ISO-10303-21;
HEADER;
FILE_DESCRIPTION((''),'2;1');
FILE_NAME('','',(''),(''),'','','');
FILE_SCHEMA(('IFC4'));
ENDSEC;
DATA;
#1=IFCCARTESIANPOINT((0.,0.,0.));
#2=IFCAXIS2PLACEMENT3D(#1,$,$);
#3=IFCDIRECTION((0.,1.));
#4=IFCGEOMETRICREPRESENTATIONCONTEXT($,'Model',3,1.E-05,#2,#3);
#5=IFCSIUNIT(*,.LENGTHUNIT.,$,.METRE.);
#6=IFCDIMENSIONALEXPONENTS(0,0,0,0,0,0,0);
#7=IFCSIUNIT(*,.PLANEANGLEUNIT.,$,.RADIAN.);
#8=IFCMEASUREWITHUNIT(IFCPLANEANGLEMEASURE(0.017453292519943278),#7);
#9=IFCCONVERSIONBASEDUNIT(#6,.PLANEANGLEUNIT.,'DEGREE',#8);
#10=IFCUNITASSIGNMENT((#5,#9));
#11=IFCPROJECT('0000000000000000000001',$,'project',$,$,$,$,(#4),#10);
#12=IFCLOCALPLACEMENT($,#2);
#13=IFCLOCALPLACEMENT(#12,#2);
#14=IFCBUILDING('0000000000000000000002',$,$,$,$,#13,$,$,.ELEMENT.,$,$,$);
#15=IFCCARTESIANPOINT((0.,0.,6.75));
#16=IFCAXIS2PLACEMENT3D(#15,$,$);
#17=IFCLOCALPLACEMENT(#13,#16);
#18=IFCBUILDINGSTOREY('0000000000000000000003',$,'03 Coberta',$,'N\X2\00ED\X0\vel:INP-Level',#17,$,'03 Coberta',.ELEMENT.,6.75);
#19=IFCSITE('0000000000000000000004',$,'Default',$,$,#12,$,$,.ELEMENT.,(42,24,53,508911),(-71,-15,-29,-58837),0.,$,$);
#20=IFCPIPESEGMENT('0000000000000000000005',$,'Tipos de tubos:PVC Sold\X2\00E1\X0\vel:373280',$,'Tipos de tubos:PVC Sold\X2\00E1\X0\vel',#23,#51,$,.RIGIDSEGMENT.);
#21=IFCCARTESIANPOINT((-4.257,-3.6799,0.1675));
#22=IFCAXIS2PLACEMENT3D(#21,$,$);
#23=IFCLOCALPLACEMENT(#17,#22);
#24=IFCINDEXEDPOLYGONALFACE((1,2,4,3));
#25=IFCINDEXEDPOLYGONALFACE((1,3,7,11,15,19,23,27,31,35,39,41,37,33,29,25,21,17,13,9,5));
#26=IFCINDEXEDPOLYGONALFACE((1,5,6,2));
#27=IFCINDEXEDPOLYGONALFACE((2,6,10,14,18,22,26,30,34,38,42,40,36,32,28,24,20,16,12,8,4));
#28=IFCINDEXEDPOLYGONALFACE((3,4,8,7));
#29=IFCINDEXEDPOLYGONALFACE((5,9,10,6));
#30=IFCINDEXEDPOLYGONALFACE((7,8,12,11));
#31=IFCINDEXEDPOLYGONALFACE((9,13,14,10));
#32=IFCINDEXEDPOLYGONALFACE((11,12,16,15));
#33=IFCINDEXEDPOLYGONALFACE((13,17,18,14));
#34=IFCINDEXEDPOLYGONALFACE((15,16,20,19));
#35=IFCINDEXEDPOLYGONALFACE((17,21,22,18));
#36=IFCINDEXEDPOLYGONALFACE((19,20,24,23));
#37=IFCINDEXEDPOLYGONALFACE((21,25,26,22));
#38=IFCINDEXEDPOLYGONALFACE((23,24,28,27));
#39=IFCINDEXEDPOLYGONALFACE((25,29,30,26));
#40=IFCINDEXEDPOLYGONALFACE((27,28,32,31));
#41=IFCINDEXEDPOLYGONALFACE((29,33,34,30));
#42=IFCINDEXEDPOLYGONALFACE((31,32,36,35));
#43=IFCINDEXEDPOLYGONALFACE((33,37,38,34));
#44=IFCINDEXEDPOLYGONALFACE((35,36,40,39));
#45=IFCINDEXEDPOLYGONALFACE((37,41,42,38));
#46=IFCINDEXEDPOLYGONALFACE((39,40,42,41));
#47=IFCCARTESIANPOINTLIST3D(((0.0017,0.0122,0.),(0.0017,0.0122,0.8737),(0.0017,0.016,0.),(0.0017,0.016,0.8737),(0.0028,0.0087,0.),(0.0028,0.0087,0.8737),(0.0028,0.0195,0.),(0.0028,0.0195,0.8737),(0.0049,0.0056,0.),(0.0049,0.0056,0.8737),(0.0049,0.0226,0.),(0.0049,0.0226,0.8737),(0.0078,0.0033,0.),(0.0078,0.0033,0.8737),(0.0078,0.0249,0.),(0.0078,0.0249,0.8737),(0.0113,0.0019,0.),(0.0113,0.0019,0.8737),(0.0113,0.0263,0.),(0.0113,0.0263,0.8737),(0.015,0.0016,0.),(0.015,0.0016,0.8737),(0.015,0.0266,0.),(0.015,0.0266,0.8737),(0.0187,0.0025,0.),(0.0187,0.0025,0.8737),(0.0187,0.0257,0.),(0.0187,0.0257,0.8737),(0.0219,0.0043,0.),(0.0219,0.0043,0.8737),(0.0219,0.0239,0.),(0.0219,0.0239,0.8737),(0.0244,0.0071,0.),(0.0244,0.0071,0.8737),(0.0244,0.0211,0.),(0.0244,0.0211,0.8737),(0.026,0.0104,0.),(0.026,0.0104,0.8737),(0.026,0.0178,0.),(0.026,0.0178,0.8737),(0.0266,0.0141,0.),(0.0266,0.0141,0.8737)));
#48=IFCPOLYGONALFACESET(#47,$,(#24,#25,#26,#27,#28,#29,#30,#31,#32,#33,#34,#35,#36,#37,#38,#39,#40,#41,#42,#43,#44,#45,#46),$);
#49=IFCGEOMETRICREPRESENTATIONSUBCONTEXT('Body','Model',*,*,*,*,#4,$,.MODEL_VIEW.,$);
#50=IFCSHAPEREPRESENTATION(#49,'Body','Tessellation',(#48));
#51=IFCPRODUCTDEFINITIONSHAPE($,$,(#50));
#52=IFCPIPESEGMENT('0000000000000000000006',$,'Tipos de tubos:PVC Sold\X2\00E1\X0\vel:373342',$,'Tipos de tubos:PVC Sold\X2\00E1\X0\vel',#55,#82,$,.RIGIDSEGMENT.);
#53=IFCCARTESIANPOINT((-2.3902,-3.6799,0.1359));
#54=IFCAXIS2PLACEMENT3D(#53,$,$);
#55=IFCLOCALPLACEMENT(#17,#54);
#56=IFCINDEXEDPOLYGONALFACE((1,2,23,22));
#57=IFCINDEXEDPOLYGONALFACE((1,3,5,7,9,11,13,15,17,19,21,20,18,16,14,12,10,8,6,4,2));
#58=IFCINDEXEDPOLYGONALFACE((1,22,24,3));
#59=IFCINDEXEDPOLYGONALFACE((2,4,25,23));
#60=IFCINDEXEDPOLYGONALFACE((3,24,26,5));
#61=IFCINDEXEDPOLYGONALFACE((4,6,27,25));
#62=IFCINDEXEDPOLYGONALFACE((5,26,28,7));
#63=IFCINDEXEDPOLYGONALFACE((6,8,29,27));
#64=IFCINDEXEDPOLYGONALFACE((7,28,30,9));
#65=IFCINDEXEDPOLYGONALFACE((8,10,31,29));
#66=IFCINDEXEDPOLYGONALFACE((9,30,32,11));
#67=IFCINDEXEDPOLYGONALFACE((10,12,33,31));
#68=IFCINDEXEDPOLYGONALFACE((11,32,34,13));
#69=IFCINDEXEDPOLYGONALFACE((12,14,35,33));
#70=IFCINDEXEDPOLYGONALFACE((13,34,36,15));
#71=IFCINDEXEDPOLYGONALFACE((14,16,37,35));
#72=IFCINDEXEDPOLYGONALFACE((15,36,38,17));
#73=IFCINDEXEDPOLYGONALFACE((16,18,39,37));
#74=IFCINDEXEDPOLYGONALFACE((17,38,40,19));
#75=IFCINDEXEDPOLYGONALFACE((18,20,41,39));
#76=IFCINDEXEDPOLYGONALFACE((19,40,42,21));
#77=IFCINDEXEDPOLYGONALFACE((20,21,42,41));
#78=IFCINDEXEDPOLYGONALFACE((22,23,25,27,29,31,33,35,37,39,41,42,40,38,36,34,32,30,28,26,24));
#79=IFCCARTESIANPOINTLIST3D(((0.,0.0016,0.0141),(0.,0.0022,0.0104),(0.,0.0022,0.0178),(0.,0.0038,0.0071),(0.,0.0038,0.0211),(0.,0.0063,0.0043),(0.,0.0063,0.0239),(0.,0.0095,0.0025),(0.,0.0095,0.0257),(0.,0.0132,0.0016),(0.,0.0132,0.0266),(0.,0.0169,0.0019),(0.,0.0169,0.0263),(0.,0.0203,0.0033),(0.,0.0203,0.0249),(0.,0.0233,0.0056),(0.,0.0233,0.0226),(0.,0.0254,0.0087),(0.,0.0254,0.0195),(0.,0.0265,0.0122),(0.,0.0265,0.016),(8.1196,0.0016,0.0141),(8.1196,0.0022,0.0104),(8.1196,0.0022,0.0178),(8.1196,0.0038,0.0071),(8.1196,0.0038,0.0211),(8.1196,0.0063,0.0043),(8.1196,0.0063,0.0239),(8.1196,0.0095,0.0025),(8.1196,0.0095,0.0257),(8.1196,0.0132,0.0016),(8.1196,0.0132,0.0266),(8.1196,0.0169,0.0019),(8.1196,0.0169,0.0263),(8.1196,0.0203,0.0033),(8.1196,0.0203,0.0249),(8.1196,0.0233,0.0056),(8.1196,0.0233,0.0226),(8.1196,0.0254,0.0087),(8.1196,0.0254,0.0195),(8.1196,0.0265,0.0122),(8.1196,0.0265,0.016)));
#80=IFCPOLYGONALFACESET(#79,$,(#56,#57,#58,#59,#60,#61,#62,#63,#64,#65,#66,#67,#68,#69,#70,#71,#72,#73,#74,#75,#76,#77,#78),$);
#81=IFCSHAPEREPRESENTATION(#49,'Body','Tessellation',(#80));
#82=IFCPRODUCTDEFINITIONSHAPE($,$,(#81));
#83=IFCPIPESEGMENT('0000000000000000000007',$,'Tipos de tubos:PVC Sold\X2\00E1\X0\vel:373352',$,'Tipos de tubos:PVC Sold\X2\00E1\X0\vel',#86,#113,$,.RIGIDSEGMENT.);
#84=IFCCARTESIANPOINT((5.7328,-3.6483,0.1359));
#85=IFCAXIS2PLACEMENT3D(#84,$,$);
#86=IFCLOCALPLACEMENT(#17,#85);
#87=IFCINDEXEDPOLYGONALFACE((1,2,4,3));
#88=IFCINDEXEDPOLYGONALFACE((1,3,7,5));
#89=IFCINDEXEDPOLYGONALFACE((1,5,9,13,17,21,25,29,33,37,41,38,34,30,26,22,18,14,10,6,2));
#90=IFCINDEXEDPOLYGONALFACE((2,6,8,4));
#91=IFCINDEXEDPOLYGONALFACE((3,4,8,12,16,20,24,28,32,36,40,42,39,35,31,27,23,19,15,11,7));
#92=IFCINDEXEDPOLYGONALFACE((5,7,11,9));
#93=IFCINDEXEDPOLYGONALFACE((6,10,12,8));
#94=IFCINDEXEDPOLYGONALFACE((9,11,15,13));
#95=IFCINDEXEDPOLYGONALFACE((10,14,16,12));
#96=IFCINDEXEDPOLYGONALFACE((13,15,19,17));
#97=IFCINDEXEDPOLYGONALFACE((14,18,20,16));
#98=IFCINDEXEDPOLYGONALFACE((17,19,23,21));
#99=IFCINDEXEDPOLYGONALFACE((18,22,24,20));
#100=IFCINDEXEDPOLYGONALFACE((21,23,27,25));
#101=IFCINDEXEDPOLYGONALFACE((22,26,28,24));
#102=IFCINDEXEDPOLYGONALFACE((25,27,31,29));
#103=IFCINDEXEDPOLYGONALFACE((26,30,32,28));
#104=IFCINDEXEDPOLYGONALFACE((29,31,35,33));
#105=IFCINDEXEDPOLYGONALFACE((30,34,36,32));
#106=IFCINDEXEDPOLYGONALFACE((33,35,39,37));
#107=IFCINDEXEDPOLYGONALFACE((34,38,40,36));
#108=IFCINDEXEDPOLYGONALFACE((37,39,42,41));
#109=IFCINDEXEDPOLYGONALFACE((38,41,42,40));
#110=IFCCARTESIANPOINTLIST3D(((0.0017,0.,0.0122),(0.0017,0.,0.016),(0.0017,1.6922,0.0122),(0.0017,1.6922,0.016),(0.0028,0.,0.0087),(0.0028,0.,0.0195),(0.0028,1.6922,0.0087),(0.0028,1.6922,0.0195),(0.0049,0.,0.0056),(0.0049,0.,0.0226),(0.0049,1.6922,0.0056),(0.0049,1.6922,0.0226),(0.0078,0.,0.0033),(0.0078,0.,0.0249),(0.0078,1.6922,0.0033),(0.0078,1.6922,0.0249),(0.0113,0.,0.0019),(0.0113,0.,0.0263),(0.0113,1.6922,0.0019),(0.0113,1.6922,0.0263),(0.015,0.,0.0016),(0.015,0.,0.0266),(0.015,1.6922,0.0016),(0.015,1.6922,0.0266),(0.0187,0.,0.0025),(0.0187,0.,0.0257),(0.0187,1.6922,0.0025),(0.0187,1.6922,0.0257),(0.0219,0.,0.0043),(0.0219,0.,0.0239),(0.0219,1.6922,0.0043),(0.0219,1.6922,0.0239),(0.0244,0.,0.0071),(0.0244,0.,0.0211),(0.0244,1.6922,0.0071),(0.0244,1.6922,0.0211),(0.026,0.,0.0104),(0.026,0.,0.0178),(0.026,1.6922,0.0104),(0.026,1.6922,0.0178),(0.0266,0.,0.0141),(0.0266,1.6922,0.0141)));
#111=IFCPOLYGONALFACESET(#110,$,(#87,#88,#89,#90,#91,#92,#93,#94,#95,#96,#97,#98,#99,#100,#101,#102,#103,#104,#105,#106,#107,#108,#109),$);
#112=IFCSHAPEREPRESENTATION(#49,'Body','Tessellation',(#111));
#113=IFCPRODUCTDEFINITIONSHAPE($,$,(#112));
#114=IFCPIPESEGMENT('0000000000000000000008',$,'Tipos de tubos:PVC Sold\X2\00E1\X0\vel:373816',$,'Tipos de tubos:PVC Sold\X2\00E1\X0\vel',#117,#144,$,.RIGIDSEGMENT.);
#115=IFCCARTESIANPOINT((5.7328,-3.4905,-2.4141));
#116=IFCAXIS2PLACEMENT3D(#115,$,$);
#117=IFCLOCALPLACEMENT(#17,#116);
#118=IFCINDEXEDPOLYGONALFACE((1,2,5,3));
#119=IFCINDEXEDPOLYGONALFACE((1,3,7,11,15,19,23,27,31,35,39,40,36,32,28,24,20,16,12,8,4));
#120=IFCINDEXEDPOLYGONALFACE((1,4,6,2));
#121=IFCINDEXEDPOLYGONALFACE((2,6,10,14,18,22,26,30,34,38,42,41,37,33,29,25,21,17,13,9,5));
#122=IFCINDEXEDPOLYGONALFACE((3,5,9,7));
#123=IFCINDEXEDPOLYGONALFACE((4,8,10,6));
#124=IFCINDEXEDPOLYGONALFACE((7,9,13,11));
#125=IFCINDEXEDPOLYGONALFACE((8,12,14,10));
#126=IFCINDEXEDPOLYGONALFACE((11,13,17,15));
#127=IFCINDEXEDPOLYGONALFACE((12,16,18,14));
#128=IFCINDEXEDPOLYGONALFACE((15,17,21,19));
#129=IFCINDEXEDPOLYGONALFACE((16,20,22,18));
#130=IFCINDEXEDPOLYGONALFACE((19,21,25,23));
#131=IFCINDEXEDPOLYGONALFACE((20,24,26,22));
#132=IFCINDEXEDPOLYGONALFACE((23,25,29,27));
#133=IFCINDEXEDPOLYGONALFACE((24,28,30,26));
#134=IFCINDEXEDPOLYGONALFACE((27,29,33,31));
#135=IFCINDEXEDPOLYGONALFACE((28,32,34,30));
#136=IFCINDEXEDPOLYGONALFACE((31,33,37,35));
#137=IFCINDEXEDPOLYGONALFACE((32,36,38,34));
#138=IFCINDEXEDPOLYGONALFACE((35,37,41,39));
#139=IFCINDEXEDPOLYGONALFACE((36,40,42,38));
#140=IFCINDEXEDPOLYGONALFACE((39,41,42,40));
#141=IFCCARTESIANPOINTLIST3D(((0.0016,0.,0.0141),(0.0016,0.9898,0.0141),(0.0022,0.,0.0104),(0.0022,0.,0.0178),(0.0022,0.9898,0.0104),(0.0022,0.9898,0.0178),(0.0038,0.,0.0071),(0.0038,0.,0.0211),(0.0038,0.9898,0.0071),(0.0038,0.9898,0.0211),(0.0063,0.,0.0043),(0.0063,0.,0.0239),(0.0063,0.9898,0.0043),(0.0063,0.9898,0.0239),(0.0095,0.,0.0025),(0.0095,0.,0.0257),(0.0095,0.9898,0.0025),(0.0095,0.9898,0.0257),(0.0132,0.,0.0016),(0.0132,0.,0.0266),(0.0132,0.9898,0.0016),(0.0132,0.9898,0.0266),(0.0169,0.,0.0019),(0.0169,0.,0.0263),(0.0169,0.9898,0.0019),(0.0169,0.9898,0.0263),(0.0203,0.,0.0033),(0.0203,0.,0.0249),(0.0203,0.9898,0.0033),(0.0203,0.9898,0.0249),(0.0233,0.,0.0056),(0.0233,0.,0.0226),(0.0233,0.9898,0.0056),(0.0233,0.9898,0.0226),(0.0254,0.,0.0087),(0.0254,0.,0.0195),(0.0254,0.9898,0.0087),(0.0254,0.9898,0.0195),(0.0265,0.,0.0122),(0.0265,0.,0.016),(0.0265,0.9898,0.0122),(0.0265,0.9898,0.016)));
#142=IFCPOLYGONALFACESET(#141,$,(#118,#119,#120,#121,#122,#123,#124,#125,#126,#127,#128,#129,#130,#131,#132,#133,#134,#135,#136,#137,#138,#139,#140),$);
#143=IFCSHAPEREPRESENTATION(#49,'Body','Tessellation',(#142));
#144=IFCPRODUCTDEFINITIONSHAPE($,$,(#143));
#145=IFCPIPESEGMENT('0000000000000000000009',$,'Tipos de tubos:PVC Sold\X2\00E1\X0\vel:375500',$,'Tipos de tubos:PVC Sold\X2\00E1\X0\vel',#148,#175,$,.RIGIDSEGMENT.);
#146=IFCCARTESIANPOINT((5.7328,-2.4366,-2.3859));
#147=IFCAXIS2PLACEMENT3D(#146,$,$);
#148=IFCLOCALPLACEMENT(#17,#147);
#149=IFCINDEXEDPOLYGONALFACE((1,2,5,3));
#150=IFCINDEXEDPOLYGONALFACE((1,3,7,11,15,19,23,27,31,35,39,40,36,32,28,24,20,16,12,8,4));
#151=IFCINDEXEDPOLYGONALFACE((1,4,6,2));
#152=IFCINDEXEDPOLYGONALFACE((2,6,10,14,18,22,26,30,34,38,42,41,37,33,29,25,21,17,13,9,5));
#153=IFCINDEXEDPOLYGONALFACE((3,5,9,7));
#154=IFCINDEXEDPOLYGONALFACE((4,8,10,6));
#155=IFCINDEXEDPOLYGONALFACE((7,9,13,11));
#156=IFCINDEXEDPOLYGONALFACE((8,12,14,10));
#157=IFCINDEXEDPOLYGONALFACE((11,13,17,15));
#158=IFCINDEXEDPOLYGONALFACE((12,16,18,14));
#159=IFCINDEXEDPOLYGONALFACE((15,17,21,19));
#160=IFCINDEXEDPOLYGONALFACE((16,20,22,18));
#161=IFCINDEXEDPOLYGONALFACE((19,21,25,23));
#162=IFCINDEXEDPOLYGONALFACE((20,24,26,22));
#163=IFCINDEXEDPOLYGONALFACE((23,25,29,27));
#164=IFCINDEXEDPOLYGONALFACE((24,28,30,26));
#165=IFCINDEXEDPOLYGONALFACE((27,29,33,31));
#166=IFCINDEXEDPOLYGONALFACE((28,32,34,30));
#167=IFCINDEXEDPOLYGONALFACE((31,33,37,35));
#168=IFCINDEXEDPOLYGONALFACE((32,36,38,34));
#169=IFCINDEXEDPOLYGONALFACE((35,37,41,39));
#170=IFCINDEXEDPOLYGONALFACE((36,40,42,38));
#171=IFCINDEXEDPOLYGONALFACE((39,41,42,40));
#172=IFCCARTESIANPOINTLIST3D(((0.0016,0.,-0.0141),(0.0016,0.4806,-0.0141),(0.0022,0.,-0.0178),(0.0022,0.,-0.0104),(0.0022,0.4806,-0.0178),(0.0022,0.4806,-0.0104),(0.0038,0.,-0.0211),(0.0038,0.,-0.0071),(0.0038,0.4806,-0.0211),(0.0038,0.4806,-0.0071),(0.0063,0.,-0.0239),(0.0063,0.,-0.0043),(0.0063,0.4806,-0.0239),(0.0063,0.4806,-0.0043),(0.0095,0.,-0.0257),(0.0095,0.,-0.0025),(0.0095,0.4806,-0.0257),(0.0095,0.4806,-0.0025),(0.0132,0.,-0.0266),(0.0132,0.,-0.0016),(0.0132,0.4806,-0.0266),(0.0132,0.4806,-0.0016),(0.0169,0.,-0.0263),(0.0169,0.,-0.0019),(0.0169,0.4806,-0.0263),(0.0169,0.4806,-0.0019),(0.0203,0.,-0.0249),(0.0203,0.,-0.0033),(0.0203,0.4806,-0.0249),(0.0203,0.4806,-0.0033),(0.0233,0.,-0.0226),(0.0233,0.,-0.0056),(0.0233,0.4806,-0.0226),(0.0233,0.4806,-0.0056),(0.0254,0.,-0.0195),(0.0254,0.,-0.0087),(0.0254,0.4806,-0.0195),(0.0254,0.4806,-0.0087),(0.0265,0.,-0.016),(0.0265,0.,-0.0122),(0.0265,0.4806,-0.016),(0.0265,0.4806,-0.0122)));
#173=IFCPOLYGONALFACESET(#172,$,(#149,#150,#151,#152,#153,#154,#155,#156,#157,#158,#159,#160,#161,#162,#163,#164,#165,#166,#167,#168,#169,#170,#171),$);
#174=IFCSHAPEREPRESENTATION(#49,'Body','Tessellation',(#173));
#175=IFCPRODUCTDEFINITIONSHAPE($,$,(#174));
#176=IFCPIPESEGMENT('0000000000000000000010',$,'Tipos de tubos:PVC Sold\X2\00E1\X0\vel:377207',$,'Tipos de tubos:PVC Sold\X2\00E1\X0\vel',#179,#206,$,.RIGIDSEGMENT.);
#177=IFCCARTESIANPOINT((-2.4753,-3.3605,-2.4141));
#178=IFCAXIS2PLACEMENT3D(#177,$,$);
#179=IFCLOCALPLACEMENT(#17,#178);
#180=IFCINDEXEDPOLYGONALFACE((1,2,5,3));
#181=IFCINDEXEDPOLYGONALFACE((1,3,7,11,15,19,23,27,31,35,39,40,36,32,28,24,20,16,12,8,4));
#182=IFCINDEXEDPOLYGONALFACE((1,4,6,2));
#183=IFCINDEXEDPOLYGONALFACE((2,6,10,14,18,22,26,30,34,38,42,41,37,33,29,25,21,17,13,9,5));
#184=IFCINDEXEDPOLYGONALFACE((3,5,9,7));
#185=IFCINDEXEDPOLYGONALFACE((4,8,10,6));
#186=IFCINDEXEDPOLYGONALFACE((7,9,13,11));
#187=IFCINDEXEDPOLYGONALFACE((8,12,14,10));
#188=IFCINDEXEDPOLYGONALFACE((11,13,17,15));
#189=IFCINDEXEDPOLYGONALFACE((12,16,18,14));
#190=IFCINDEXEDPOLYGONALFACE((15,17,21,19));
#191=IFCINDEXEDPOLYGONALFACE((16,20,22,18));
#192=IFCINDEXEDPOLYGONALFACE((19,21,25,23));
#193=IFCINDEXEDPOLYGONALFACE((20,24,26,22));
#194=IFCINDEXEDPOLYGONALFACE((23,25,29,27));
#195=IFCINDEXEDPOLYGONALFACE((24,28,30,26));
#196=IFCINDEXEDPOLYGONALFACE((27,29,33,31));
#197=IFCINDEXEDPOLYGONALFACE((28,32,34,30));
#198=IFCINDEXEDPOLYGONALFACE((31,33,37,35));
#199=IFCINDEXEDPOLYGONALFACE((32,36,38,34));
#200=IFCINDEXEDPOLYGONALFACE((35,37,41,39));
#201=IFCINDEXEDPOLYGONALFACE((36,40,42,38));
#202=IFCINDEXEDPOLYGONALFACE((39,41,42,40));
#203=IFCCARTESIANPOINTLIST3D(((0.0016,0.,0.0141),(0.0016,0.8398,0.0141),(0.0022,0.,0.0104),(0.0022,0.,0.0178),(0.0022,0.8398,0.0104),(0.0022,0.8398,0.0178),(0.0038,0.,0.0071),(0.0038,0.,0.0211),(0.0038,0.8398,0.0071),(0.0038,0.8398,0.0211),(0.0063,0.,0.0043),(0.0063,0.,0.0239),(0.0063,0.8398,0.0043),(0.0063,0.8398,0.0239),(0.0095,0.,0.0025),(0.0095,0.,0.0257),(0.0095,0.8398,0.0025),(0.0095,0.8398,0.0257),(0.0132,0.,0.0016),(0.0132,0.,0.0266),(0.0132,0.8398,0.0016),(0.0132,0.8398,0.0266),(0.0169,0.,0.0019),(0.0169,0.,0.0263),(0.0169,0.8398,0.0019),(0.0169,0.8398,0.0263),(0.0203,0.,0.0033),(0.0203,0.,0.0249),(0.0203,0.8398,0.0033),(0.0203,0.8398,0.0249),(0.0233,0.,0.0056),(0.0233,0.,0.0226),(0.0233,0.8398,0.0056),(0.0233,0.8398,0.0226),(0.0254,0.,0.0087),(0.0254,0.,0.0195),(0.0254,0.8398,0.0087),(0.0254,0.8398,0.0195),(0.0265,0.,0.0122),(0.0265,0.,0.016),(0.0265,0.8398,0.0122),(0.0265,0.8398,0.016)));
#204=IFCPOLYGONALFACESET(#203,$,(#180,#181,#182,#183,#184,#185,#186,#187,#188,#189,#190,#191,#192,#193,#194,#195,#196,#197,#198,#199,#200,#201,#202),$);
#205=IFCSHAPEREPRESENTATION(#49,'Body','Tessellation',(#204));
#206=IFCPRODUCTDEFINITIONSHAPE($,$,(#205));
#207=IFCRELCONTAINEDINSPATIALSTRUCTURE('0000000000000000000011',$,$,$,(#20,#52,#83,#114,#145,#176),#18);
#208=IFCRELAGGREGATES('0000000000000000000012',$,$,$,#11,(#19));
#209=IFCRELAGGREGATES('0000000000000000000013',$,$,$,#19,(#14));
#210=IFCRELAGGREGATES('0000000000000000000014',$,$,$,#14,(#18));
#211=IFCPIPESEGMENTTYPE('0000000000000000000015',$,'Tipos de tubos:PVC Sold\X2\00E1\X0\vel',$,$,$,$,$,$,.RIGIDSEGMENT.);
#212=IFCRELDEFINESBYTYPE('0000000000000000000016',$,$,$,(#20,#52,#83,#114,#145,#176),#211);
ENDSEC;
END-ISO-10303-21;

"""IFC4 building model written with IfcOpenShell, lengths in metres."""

from ifc_helpers import new_model, entity, si_unit, converted_unit, direction, frame, frame_2d, origin, origin_2d_with_axis, place, context, subcontext, project, spatial, circle, extrude, type_object, element, save


model = new_model("IFC4")

# Units and contexts
model_context = context("Model", 3, precision=1e-05, world=origin(), true_north=direction((0.0, 1.0)))
body_context = subcontext(model_context, "Body", "Model", "MODEL_VIEW")
ifc_project = project(units=[si_unit("LENGTHUNIT", "METRE"), converted_unit("PLANEANGLEUNIT", "DEGREE", entity("IfcPlaneAngleMeasure", 0.017453292519943278), si_unit("PLANEANGLEUNIT", "RADIAN"), dimensions=[0, 0, 0, 0, 0, 0, 0])], contexts=[model_context])

# Site, building, storey
site_placement = place(None, origin())
site = spatial("IfcSite", under=ifc_project, at=site_placement, Name="Default", CompositionType="ELEMENT", RefLatitude=(42, 24, 53, 508911), RefLongitude=(-71, -15, -29, -58837), RefElevation=0.0)
building_placement = place(site_placement, origin())
building = spatial("IfcBuilding", under=site, at=building_placement, CompositionType="ELEMENT")
storey_placement = place(building_placement, frame((0.0, 0.0, 6.75)))
storey = spatial("IfcBuildingStorey", under=building, at=storey_placement, Name="03 Coberta", ObjectType="Nível:INP-Level", LongName="03 Coberta", CompositionType="ELEMENT", Elevation=6.75)

# Pipe segments
pipe_segment_type = type_object("IfcPipeSegmentType", Name="Tipos de tubos:PVC Soldável", PredefinedType="RIGIDSEGMENT")
pipe_segment_1_placement = place(storey_placement, frame((-4.257, -3.6799, 0.1675)))
element("IfcPipeSegment", 1, at=pipe_segment_1_placement, inside=storey, type_object=pipe_segment_type, Name="Tipos de tubos:PVC Soldável:373280", ObjectType="Tipos de tubos:PVC Soldável", PredefinedType="RIGIDSEGMENT", context=body_context, shape_type="SweptSolid", body=[
    extrude(circle(Radius=0.0125, at=origin_2d_with_axis()), frame((0.0141, 0.0141, 0.0)), (0.0, 0.0, 1.0), 0.8737),
])
pipe_segment_2_placement = place(storey_placement, frame((-2.3902, -3.6799, 0.1359)))
element("IfcPipeSegment", 2, at=pipe_segment_2_placement, inside=storey, type_object=pipe_segment_type, Name="Tipos de tubos:PVC Soldável:373342", ObjectType="Tipos de tubos:PVC Soldável", PredefinedType="RIGIDSEGMENT", context=body_context, shape_type="SweptSolid", body=[
    extrude(circle(Radius=0.0125, at=origin_2d_with_axis()), frame((0.0, 0.0141, 0.0141), z_axis=(1.0, 0.0, 0.0), x_axis=(0.0, -1.0, 0.0)), (0.0, 0.0, 1.0), 8.1196),
])
pipe_segment_3_placement = place(storey_placement, frame((5.7328, -3.6483, 0.1359)))
element("IfcPipeSegment", 3, at=pipe_segment_3_placement, inside=storey, type_object=pipe_segment_type, Name="Tipos de tubos:PVC Soldável:373352", ObjectType="Tipos de tubos:PVC Soldável", PredefinedType="RIGIDSEGMENT", context=body_context, shape_type="SweptSolid", body=[
    extrude(circle(Radius=0.0125, at=origin_2d_with_axis()), frame((0.0141, 0.0, 0.0141), z_axis=(0.0, 1.0, 0.0), x_axis=(1.0, 0.0, 0.0)), (0.0, 0.0, 1.0), 1.6922),
])
pipe_segment_4_placement = place(storey_placement, frame((5.7328, -3.4905, -2.4141)))
element("IfcPipeSegment", 4, at=pipe_segment_4_placement, inside=storey, type_object=pipe_segment_type, Name="Tipos de tubos:PVC Soldável:373816", ObjectType="Tipos de tubos:PVC Soldável", PredefinedType="RIGIDSEGMENT", context=body_context, shape_type="SweptSolid", body=[
    extrude(circle(Radius=0.0125, at=origin_2d_with_axis()), frame((0.0141, 0.0, 0.0141), z_axis=(0.0, 1.0, 0.0), x_axis=(-1.0, 0.0, 0.0)), (0.0, 0.0, 1.0), 0.9898),
])
pipe_segment_5_placement = place(storey_placement, frame((5.7328, -2.4366, -2.3859)))
element("IfcPipeSegment", 5, at=pipe_segment_5_placement, inside=storey, type_object=pipe_segment_type, Name="Tipos de tubos:PVC Soldável:375500", ObjectType="Tipos de tubos:PVC Soldável", PredefinedType="RIGIDSEGMENT", context=body_context, shape_type="SweptSolid", body=[
    extrude(circle(Radius=0.0125, at=frame_2d((0.0, 0.0), x_axis=(1.0, 0.0))), frame((0.0141, 0.0, -0.0141), z_axis=(0.0, 1.0, 0.0), x_axis=(-1.0, 0.0, 0.0)), (0.0, 0.0, 1.0), 0.4806),
])
pipe_segment_6_placement = place(storey_placement, frame((-2.4753, -3.3605, -2.4141)))
element("IfcPipeSegment", 6, at=pipe_segment_6_placement, inside=storey, type_object=pipe_segment_type, Name="Tipos de tubos:PVC Soldável:377207", ObjectType="Tipos de tubos:PVC Soldável", PredefinedType="RIGIDSEGMENT", context=body_context, shape_type="SweptSolid", body=[
    extrude(circle(Radius=0.0125, at=origin_2d_with_axis()), frame((0.0141, 0.0, 0.0141), z_axis=(0.0, 1.0, 0.0), x_axis=(-1.0, 0.0, 0.0)), (0.0, 0.0, 1.0), 0.8398),
])

save(model, "model.ifc")
